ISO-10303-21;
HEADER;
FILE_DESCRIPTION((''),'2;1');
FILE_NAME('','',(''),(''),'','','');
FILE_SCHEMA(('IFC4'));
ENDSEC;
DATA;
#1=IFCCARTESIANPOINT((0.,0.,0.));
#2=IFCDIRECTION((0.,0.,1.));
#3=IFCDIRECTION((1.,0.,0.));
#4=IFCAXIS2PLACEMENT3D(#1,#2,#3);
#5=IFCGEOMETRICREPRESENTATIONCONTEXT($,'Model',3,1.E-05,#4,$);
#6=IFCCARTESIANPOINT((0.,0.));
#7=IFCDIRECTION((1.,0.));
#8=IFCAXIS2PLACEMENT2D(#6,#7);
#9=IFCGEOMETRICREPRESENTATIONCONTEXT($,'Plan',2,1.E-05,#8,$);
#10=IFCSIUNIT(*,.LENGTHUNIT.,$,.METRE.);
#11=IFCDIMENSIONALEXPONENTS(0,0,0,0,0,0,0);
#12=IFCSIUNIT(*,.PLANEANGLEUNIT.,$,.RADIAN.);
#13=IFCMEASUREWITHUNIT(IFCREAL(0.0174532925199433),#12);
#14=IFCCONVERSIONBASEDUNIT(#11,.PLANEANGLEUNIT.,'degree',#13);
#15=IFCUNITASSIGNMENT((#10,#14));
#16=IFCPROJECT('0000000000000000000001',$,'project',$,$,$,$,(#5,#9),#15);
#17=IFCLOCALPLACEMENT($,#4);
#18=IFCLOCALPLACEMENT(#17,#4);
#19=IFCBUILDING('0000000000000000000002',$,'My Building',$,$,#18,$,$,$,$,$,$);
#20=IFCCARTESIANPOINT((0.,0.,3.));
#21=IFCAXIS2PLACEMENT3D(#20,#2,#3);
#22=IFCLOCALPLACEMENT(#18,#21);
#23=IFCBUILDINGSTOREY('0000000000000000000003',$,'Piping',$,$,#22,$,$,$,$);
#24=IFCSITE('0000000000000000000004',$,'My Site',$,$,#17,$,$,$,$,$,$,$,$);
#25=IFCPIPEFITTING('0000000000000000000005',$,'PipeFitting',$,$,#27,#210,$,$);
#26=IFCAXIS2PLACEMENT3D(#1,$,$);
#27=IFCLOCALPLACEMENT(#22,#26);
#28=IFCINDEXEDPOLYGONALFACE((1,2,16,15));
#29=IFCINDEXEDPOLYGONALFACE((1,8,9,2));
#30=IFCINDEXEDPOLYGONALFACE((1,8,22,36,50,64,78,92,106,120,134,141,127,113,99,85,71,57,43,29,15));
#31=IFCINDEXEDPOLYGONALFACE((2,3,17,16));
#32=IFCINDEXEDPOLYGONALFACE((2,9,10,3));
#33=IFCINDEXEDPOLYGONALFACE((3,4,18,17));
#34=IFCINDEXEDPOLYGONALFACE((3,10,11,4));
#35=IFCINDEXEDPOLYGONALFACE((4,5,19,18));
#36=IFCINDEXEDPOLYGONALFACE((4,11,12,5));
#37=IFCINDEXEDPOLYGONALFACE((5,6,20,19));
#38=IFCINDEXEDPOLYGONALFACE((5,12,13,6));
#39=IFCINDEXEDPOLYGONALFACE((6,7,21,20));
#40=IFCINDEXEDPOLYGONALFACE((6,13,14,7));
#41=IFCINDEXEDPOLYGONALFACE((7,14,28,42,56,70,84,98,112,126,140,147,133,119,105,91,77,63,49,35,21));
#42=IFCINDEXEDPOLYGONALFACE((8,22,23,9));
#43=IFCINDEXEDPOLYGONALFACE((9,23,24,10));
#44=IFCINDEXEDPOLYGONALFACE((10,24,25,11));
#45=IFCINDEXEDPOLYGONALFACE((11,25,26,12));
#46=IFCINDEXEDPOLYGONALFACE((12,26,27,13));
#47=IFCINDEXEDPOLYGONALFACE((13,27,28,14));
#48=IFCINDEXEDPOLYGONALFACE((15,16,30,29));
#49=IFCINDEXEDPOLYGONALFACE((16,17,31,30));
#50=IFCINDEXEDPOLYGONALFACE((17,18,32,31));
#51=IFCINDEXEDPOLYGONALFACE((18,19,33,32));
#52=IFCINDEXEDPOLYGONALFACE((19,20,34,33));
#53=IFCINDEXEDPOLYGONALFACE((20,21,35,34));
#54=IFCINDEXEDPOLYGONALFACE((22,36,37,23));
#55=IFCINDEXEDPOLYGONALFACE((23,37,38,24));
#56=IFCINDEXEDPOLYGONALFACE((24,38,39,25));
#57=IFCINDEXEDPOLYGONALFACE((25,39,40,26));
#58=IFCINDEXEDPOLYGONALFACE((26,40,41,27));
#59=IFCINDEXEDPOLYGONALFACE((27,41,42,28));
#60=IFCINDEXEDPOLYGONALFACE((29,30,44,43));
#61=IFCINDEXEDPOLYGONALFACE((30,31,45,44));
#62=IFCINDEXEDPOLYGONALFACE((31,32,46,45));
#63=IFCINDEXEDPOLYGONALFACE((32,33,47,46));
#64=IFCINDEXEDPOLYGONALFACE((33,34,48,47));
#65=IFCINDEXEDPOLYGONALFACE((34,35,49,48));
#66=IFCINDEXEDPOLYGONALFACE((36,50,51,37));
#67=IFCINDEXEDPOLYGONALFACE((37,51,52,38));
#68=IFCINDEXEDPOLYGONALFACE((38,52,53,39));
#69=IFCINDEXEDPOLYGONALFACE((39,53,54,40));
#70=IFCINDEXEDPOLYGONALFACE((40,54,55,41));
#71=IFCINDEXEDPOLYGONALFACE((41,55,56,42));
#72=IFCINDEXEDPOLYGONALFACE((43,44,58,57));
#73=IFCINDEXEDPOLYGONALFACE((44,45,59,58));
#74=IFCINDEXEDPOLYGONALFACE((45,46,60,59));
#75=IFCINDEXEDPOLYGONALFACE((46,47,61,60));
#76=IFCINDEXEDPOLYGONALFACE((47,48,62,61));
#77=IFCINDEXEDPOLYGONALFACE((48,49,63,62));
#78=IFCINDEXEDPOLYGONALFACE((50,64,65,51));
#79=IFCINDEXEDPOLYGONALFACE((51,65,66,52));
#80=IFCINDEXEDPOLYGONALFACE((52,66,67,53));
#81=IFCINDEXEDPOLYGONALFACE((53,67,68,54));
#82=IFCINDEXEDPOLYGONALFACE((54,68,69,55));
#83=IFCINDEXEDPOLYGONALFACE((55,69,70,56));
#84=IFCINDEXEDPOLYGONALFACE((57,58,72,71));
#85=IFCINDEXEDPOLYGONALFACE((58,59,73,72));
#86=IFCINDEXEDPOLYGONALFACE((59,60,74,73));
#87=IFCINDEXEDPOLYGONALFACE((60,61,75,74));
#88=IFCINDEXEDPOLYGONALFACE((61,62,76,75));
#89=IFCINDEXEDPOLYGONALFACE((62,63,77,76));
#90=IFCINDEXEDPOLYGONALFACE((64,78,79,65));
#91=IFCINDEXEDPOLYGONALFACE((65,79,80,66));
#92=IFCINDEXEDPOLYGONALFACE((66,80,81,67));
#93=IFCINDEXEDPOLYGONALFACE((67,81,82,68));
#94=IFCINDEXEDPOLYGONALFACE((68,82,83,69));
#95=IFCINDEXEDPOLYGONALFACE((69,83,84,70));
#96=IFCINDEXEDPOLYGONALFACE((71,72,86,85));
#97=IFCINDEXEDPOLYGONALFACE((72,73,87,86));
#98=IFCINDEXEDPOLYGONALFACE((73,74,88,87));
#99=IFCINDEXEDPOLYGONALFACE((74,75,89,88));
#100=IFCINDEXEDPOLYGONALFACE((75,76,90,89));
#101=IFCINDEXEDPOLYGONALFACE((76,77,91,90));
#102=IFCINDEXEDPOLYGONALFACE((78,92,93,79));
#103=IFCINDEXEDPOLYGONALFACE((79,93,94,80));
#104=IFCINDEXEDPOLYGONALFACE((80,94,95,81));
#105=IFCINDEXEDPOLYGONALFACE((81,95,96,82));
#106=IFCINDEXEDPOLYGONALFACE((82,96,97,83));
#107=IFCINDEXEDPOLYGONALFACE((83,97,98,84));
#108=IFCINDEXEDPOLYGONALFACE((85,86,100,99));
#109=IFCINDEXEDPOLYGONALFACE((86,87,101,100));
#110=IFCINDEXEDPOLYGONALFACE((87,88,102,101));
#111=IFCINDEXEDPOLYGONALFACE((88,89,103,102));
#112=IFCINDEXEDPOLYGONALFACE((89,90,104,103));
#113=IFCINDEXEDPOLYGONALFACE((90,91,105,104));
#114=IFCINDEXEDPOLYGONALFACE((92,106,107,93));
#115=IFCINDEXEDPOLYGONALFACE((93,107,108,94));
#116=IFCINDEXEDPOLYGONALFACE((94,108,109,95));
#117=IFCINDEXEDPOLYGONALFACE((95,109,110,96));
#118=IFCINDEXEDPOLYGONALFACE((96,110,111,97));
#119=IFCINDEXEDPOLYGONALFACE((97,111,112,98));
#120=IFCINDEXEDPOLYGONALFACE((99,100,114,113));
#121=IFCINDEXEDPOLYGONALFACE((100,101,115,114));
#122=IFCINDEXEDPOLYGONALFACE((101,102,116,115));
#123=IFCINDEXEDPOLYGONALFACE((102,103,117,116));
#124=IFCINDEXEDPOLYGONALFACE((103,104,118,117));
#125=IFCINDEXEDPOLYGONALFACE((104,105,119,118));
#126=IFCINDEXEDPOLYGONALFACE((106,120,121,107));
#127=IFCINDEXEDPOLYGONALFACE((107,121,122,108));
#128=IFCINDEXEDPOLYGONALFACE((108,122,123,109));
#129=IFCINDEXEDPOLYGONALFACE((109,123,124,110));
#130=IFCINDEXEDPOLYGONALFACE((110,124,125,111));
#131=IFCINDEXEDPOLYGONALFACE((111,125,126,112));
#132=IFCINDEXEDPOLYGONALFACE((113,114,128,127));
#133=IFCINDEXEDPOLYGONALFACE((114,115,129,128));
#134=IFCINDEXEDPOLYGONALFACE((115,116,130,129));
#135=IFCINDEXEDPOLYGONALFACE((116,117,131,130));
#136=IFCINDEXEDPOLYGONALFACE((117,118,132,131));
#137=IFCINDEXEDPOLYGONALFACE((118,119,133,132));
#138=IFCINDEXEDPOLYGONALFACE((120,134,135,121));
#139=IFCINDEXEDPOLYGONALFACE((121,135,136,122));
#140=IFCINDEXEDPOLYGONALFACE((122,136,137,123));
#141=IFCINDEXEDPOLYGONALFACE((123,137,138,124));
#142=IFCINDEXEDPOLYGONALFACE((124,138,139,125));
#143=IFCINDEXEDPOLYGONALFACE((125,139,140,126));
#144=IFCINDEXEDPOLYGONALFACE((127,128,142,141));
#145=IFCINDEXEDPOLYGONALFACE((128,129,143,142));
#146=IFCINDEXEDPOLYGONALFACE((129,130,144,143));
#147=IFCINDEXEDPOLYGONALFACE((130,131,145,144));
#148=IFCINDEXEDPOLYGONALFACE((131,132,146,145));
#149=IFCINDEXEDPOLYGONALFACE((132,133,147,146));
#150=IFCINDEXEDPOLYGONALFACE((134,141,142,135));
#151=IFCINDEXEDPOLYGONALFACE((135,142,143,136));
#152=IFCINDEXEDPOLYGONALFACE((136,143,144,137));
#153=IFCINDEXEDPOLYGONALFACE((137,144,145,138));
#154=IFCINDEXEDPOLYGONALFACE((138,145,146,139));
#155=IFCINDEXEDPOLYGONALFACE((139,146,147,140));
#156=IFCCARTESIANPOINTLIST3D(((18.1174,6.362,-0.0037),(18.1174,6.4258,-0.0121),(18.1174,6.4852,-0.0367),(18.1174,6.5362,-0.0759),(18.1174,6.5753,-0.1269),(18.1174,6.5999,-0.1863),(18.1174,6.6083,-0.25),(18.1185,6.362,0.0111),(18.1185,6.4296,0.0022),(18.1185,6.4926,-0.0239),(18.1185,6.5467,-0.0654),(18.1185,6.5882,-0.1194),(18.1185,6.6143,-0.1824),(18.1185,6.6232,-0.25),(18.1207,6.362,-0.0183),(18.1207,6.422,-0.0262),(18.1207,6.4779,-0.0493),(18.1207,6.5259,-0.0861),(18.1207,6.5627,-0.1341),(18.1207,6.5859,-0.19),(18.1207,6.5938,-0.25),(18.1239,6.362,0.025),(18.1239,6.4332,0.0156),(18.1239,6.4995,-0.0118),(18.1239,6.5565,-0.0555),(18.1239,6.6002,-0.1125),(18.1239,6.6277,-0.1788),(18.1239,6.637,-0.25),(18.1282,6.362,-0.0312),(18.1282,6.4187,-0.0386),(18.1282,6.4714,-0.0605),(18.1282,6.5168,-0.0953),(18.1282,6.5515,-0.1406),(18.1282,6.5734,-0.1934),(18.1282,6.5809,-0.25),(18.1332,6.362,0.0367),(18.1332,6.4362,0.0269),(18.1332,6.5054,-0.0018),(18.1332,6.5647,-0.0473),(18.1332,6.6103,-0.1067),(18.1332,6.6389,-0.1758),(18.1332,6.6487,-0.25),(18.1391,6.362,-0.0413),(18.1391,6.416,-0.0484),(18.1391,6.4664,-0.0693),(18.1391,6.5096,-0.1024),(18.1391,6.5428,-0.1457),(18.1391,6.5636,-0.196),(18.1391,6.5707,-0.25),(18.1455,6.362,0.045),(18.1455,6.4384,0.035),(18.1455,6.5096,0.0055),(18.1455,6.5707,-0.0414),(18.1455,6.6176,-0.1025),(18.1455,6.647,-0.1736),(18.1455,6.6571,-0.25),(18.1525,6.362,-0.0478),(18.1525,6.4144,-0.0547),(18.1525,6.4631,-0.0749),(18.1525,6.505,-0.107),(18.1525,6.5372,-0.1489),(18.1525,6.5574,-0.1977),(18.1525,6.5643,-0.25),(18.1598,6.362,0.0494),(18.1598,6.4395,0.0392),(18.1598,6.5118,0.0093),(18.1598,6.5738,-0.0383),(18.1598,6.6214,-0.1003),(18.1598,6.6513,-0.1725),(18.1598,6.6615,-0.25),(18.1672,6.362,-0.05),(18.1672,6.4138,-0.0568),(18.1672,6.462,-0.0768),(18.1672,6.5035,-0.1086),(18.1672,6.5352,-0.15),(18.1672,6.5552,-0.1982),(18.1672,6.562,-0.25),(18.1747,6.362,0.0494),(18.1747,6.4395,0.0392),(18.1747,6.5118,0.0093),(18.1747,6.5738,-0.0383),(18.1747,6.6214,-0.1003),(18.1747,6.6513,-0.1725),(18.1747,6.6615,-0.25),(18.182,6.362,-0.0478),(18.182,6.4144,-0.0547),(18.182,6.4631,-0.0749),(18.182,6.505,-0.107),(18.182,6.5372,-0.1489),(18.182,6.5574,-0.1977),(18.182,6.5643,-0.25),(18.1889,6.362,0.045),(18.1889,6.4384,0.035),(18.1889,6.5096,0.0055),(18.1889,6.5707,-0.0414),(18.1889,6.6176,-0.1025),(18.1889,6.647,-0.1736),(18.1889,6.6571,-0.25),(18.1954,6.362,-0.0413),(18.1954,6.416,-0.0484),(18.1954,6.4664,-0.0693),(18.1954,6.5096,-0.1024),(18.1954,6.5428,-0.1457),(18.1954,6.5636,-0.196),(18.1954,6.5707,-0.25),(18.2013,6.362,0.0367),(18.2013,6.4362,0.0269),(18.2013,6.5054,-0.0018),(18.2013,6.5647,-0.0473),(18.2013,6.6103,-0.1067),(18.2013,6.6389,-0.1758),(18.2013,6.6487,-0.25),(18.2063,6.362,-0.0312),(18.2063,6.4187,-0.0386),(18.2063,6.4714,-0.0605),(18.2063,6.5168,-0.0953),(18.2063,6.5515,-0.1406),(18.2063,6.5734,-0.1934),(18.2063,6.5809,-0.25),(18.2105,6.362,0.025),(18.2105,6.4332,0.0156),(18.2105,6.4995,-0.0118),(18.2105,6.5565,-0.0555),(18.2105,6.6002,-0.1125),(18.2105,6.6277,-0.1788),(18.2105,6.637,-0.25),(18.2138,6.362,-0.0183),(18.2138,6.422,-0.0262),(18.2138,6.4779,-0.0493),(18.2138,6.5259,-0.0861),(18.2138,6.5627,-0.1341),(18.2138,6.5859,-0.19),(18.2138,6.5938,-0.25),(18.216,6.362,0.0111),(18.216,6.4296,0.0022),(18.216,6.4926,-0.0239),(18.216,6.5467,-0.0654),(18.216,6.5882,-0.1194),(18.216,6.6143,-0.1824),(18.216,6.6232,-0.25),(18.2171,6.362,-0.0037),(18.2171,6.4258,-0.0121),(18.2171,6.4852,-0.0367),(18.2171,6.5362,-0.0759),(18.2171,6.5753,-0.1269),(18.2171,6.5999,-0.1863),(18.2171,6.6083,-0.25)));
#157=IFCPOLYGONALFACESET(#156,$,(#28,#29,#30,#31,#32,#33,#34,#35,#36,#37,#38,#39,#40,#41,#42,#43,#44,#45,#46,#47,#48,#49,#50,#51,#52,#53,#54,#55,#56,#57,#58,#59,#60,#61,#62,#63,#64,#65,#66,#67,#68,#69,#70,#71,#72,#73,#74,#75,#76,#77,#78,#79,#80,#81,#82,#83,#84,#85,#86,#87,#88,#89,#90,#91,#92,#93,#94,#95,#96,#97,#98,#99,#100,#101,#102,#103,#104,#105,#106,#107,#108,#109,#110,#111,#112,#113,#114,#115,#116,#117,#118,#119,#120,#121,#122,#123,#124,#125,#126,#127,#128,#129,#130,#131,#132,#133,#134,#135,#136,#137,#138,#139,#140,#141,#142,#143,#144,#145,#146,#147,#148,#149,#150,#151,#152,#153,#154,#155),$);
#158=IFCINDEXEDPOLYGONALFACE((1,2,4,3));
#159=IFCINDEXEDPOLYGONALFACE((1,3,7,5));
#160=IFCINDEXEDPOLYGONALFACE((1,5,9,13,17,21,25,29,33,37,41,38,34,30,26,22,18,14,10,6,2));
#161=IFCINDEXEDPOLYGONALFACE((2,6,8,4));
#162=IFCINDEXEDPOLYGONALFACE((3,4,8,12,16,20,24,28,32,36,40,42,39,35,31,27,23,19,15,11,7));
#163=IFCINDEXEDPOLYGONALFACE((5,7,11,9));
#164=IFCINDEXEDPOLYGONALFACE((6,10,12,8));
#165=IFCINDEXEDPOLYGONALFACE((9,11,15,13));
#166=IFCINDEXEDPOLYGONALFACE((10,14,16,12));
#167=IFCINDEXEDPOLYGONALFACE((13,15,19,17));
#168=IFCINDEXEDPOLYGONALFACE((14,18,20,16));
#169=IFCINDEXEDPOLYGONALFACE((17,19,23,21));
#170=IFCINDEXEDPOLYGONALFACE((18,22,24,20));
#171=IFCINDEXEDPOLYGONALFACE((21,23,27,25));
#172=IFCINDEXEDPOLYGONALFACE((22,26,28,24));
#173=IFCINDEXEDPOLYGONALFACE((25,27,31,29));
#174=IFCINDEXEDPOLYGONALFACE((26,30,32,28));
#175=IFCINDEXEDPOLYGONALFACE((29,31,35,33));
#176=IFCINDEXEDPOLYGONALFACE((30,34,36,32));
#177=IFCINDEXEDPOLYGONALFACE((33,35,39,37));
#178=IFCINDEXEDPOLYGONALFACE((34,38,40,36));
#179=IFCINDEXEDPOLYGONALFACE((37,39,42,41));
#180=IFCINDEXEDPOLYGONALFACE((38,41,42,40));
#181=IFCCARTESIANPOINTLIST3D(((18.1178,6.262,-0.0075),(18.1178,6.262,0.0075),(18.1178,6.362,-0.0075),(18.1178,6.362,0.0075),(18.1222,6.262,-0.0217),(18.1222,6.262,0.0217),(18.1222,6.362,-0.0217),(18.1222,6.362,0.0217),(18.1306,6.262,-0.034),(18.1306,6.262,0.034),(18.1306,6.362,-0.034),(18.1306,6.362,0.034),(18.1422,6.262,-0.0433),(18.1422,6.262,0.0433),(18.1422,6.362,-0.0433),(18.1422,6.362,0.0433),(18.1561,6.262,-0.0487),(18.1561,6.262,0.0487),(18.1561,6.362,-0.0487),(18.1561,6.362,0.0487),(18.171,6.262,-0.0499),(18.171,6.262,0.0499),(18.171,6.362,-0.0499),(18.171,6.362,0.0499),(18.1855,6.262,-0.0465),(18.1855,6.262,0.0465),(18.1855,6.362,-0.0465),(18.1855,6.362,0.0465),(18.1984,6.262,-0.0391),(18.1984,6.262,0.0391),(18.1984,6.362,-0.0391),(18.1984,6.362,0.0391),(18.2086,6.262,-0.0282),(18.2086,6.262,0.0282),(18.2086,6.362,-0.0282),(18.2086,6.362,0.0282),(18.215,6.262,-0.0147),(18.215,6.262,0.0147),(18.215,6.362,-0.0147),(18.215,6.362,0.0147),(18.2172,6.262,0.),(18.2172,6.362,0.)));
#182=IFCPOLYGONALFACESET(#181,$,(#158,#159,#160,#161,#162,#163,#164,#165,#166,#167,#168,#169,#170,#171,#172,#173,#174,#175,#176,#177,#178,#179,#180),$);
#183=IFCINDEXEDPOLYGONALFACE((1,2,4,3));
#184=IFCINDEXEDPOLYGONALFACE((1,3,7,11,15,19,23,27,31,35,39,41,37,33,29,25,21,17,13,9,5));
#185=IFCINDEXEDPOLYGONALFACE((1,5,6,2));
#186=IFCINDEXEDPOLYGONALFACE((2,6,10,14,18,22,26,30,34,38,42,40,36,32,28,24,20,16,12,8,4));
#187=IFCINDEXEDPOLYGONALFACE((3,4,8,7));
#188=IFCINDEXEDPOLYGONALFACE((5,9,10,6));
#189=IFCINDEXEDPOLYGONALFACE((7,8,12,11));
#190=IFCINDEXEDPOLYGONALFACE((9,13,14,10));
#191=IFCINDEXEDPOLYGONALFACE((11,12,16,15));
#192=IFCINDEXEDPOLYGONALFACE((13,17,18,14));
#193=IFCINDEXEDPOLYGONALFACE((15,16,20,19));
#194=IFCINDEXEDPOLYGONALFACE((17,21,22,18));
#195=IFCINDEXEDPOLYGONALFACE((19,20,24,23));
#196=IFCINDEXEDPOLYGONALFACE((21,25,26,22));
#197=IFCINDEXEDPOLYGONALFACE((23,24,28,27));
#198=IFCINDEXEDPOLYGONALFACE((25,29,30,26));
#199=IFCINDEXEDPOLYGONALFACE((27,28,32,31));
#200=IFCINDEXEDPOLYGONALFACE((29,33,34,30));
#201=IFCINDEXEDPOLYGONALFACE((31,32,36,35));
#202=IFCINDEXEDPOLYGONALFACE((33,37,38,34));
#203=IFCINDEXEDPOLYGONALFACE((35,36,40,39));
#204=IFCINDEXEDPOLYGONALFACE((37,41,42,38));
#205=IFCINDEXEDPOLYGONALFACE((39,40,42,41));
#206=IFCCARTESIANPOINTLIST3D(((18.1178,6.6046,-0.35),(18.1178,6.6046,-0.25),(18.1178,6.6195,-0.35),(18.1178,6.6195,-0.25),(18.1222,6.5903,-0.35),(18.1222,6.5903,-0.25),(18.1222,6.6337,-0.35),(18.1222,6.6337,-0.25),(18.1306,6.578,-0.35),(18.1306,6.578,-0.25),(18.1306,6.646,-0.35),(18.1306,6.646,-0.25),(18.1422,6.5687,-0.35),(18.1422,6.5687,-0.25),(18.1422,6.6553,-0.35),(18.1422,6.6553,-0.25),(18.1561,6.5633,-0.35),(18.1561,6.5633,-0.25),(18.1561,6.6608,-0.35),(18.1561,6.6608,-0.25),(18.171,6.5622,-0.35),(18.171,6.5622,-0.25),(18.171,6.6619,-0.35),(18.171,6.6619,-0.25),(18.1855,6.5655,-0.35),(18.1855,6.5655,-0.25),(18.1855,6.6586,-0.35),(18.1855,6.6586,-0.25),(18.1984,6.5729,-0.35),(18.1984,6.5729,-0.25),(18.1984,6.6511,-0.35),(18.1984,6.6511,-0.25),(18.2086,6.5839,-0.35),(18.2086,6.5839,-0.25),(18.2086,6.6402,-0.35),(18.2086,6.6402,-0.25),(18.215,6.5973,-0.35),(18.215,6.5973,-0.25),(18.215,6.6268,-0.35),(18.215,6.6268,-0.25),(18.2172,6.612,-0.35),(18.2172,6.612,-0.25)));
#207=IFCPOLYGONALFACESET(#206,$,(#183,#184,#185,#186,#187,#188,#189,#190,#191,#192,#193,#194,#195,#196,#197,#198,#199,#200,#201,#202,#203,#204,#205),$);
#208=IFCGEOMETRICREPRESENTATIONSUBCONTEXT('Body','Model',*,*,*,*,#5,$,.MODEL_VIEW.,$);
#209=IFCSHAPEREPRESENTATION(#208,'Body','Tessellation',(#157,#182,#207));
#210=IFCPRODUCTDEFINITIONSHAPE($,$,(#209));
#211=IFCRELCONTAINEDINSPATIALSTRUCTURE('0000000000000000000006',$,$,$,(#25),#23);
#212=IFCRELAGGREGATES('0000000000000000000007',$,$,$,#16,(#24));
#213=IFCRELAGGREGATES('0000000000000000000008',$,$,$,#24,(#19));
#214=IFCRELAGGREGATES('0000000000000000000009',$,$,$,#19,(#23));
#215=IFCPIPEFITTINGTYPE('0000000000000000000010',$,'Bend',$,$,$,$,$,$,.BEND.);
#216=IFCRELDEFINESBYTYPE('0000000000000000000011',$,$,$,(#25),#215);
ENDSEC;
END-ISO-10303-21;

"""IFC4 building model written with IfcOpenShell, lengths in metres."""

from ifc_helpers import new_model, entity, si_unit, converted_unit, frame, origin_with_axes, origin_2d_with_axis, place, context, subcontext, project, spatial, circle, extrude, source, transform, mapped, type_object, type_shapes, element, save


model = new_model("IFC4")

# Units and contexts
model_context = context("Model", 3, precision=1e-05, world=origin_with_axes())
plan_context = context("Plan", 2, precision=1e-05, world=origin_2d_with_axis())
body_context = subcontext(model_context, "Body", "Model", "MODEL_VIEW")
ifc_project = project(units=[si_unit("LENGTHUNIT", "METRE"), converted_unit("PLANEANGLEUNIT", "degree", entity("IfcReal", 0.0174532925199433), si_unit("PLANEANGLEUNIT", "RADIAN"), dimensions=[0, 0, 0, 0, 0, 0, 0])], contexts=[model_context, plan_context])

# Site, building, storey
site_placement = place(None, origin_with_axes())
site = spatial("IfcSite", under=ifc_project, at=site_placement, Name="My Site")
building_placement = place(site_placement, origin_with_axes())
building = spatial("IfcBuilding", under=site, at=building_placement, Name="My Building")
storey_placement = place(building_placement, frame((0.0, 0.0, 3.0), z_axis=(0.0, 0.0, 1.0), x_axis=(1.0, 0.0, 0.0)))
storey = spatial("IfcBuildingStorey", under=building, at=storey_placement, Name="Piping")

# Pipe fitting
pipe_fitting_type = type_object("IfcPipeFittingType", Name="Bend", PredefinedType="BEND")
shared_shape = source(origin_with_axes(), body_context, "Body", "SolidModel", [
    entity("IfcSweptDiskSolid", entity("IfcIndexedPolyCurve", entity("IfcCartesianPointList3D", [[0.0, 0.0, -0.1], [0.0, -0.0732, -0.2768], [0.0, -0.25, -0.35]]), [entity("IfcArcIndex", [1, 2, 3])]), 0.05),
    extrude(circle(Radius=0.05), origin_with_axes(), (0.0, 0.0, -1.0), 0.1),
    extrude(circle(Radius=0.05), frame((0.0, -0.25, -0.35), z_axis=(0.0, -1.0, 0.0), x_axis=(1.0, 0.0, 0.0)), (0.0, 0.0, 1.0), 0.1),
])
type_shapes(pipe_fitting_type, [shared_shape])
for number, where, z_axis, x_axis, name in (
    (1, (18.1672, 6.262, 0.0), (0.0, -1.0, 0.0), (1.0, 0.0, 0.0), "PipeFitting"),
):
    element("IfcPipeFitting", number, at=place(storey_placement, frame(where, z_axis=z_axis, x_axis=x_axis)), inside=storey, type_object=pipe_fitting_type, Name=name, context=body_context, shape_type="MappedRepresentation", body=[
        mapped(shared_shape, transform((0.0, 0.0, 0.0), x_axis=(1.0, 0.0, 0.0), y_axis=(0.0, 1.0, 0.0), z_axis=(0.0, 0.0, 1.0), scale=1.0)),
    ])

save(model, "model.ifc")
